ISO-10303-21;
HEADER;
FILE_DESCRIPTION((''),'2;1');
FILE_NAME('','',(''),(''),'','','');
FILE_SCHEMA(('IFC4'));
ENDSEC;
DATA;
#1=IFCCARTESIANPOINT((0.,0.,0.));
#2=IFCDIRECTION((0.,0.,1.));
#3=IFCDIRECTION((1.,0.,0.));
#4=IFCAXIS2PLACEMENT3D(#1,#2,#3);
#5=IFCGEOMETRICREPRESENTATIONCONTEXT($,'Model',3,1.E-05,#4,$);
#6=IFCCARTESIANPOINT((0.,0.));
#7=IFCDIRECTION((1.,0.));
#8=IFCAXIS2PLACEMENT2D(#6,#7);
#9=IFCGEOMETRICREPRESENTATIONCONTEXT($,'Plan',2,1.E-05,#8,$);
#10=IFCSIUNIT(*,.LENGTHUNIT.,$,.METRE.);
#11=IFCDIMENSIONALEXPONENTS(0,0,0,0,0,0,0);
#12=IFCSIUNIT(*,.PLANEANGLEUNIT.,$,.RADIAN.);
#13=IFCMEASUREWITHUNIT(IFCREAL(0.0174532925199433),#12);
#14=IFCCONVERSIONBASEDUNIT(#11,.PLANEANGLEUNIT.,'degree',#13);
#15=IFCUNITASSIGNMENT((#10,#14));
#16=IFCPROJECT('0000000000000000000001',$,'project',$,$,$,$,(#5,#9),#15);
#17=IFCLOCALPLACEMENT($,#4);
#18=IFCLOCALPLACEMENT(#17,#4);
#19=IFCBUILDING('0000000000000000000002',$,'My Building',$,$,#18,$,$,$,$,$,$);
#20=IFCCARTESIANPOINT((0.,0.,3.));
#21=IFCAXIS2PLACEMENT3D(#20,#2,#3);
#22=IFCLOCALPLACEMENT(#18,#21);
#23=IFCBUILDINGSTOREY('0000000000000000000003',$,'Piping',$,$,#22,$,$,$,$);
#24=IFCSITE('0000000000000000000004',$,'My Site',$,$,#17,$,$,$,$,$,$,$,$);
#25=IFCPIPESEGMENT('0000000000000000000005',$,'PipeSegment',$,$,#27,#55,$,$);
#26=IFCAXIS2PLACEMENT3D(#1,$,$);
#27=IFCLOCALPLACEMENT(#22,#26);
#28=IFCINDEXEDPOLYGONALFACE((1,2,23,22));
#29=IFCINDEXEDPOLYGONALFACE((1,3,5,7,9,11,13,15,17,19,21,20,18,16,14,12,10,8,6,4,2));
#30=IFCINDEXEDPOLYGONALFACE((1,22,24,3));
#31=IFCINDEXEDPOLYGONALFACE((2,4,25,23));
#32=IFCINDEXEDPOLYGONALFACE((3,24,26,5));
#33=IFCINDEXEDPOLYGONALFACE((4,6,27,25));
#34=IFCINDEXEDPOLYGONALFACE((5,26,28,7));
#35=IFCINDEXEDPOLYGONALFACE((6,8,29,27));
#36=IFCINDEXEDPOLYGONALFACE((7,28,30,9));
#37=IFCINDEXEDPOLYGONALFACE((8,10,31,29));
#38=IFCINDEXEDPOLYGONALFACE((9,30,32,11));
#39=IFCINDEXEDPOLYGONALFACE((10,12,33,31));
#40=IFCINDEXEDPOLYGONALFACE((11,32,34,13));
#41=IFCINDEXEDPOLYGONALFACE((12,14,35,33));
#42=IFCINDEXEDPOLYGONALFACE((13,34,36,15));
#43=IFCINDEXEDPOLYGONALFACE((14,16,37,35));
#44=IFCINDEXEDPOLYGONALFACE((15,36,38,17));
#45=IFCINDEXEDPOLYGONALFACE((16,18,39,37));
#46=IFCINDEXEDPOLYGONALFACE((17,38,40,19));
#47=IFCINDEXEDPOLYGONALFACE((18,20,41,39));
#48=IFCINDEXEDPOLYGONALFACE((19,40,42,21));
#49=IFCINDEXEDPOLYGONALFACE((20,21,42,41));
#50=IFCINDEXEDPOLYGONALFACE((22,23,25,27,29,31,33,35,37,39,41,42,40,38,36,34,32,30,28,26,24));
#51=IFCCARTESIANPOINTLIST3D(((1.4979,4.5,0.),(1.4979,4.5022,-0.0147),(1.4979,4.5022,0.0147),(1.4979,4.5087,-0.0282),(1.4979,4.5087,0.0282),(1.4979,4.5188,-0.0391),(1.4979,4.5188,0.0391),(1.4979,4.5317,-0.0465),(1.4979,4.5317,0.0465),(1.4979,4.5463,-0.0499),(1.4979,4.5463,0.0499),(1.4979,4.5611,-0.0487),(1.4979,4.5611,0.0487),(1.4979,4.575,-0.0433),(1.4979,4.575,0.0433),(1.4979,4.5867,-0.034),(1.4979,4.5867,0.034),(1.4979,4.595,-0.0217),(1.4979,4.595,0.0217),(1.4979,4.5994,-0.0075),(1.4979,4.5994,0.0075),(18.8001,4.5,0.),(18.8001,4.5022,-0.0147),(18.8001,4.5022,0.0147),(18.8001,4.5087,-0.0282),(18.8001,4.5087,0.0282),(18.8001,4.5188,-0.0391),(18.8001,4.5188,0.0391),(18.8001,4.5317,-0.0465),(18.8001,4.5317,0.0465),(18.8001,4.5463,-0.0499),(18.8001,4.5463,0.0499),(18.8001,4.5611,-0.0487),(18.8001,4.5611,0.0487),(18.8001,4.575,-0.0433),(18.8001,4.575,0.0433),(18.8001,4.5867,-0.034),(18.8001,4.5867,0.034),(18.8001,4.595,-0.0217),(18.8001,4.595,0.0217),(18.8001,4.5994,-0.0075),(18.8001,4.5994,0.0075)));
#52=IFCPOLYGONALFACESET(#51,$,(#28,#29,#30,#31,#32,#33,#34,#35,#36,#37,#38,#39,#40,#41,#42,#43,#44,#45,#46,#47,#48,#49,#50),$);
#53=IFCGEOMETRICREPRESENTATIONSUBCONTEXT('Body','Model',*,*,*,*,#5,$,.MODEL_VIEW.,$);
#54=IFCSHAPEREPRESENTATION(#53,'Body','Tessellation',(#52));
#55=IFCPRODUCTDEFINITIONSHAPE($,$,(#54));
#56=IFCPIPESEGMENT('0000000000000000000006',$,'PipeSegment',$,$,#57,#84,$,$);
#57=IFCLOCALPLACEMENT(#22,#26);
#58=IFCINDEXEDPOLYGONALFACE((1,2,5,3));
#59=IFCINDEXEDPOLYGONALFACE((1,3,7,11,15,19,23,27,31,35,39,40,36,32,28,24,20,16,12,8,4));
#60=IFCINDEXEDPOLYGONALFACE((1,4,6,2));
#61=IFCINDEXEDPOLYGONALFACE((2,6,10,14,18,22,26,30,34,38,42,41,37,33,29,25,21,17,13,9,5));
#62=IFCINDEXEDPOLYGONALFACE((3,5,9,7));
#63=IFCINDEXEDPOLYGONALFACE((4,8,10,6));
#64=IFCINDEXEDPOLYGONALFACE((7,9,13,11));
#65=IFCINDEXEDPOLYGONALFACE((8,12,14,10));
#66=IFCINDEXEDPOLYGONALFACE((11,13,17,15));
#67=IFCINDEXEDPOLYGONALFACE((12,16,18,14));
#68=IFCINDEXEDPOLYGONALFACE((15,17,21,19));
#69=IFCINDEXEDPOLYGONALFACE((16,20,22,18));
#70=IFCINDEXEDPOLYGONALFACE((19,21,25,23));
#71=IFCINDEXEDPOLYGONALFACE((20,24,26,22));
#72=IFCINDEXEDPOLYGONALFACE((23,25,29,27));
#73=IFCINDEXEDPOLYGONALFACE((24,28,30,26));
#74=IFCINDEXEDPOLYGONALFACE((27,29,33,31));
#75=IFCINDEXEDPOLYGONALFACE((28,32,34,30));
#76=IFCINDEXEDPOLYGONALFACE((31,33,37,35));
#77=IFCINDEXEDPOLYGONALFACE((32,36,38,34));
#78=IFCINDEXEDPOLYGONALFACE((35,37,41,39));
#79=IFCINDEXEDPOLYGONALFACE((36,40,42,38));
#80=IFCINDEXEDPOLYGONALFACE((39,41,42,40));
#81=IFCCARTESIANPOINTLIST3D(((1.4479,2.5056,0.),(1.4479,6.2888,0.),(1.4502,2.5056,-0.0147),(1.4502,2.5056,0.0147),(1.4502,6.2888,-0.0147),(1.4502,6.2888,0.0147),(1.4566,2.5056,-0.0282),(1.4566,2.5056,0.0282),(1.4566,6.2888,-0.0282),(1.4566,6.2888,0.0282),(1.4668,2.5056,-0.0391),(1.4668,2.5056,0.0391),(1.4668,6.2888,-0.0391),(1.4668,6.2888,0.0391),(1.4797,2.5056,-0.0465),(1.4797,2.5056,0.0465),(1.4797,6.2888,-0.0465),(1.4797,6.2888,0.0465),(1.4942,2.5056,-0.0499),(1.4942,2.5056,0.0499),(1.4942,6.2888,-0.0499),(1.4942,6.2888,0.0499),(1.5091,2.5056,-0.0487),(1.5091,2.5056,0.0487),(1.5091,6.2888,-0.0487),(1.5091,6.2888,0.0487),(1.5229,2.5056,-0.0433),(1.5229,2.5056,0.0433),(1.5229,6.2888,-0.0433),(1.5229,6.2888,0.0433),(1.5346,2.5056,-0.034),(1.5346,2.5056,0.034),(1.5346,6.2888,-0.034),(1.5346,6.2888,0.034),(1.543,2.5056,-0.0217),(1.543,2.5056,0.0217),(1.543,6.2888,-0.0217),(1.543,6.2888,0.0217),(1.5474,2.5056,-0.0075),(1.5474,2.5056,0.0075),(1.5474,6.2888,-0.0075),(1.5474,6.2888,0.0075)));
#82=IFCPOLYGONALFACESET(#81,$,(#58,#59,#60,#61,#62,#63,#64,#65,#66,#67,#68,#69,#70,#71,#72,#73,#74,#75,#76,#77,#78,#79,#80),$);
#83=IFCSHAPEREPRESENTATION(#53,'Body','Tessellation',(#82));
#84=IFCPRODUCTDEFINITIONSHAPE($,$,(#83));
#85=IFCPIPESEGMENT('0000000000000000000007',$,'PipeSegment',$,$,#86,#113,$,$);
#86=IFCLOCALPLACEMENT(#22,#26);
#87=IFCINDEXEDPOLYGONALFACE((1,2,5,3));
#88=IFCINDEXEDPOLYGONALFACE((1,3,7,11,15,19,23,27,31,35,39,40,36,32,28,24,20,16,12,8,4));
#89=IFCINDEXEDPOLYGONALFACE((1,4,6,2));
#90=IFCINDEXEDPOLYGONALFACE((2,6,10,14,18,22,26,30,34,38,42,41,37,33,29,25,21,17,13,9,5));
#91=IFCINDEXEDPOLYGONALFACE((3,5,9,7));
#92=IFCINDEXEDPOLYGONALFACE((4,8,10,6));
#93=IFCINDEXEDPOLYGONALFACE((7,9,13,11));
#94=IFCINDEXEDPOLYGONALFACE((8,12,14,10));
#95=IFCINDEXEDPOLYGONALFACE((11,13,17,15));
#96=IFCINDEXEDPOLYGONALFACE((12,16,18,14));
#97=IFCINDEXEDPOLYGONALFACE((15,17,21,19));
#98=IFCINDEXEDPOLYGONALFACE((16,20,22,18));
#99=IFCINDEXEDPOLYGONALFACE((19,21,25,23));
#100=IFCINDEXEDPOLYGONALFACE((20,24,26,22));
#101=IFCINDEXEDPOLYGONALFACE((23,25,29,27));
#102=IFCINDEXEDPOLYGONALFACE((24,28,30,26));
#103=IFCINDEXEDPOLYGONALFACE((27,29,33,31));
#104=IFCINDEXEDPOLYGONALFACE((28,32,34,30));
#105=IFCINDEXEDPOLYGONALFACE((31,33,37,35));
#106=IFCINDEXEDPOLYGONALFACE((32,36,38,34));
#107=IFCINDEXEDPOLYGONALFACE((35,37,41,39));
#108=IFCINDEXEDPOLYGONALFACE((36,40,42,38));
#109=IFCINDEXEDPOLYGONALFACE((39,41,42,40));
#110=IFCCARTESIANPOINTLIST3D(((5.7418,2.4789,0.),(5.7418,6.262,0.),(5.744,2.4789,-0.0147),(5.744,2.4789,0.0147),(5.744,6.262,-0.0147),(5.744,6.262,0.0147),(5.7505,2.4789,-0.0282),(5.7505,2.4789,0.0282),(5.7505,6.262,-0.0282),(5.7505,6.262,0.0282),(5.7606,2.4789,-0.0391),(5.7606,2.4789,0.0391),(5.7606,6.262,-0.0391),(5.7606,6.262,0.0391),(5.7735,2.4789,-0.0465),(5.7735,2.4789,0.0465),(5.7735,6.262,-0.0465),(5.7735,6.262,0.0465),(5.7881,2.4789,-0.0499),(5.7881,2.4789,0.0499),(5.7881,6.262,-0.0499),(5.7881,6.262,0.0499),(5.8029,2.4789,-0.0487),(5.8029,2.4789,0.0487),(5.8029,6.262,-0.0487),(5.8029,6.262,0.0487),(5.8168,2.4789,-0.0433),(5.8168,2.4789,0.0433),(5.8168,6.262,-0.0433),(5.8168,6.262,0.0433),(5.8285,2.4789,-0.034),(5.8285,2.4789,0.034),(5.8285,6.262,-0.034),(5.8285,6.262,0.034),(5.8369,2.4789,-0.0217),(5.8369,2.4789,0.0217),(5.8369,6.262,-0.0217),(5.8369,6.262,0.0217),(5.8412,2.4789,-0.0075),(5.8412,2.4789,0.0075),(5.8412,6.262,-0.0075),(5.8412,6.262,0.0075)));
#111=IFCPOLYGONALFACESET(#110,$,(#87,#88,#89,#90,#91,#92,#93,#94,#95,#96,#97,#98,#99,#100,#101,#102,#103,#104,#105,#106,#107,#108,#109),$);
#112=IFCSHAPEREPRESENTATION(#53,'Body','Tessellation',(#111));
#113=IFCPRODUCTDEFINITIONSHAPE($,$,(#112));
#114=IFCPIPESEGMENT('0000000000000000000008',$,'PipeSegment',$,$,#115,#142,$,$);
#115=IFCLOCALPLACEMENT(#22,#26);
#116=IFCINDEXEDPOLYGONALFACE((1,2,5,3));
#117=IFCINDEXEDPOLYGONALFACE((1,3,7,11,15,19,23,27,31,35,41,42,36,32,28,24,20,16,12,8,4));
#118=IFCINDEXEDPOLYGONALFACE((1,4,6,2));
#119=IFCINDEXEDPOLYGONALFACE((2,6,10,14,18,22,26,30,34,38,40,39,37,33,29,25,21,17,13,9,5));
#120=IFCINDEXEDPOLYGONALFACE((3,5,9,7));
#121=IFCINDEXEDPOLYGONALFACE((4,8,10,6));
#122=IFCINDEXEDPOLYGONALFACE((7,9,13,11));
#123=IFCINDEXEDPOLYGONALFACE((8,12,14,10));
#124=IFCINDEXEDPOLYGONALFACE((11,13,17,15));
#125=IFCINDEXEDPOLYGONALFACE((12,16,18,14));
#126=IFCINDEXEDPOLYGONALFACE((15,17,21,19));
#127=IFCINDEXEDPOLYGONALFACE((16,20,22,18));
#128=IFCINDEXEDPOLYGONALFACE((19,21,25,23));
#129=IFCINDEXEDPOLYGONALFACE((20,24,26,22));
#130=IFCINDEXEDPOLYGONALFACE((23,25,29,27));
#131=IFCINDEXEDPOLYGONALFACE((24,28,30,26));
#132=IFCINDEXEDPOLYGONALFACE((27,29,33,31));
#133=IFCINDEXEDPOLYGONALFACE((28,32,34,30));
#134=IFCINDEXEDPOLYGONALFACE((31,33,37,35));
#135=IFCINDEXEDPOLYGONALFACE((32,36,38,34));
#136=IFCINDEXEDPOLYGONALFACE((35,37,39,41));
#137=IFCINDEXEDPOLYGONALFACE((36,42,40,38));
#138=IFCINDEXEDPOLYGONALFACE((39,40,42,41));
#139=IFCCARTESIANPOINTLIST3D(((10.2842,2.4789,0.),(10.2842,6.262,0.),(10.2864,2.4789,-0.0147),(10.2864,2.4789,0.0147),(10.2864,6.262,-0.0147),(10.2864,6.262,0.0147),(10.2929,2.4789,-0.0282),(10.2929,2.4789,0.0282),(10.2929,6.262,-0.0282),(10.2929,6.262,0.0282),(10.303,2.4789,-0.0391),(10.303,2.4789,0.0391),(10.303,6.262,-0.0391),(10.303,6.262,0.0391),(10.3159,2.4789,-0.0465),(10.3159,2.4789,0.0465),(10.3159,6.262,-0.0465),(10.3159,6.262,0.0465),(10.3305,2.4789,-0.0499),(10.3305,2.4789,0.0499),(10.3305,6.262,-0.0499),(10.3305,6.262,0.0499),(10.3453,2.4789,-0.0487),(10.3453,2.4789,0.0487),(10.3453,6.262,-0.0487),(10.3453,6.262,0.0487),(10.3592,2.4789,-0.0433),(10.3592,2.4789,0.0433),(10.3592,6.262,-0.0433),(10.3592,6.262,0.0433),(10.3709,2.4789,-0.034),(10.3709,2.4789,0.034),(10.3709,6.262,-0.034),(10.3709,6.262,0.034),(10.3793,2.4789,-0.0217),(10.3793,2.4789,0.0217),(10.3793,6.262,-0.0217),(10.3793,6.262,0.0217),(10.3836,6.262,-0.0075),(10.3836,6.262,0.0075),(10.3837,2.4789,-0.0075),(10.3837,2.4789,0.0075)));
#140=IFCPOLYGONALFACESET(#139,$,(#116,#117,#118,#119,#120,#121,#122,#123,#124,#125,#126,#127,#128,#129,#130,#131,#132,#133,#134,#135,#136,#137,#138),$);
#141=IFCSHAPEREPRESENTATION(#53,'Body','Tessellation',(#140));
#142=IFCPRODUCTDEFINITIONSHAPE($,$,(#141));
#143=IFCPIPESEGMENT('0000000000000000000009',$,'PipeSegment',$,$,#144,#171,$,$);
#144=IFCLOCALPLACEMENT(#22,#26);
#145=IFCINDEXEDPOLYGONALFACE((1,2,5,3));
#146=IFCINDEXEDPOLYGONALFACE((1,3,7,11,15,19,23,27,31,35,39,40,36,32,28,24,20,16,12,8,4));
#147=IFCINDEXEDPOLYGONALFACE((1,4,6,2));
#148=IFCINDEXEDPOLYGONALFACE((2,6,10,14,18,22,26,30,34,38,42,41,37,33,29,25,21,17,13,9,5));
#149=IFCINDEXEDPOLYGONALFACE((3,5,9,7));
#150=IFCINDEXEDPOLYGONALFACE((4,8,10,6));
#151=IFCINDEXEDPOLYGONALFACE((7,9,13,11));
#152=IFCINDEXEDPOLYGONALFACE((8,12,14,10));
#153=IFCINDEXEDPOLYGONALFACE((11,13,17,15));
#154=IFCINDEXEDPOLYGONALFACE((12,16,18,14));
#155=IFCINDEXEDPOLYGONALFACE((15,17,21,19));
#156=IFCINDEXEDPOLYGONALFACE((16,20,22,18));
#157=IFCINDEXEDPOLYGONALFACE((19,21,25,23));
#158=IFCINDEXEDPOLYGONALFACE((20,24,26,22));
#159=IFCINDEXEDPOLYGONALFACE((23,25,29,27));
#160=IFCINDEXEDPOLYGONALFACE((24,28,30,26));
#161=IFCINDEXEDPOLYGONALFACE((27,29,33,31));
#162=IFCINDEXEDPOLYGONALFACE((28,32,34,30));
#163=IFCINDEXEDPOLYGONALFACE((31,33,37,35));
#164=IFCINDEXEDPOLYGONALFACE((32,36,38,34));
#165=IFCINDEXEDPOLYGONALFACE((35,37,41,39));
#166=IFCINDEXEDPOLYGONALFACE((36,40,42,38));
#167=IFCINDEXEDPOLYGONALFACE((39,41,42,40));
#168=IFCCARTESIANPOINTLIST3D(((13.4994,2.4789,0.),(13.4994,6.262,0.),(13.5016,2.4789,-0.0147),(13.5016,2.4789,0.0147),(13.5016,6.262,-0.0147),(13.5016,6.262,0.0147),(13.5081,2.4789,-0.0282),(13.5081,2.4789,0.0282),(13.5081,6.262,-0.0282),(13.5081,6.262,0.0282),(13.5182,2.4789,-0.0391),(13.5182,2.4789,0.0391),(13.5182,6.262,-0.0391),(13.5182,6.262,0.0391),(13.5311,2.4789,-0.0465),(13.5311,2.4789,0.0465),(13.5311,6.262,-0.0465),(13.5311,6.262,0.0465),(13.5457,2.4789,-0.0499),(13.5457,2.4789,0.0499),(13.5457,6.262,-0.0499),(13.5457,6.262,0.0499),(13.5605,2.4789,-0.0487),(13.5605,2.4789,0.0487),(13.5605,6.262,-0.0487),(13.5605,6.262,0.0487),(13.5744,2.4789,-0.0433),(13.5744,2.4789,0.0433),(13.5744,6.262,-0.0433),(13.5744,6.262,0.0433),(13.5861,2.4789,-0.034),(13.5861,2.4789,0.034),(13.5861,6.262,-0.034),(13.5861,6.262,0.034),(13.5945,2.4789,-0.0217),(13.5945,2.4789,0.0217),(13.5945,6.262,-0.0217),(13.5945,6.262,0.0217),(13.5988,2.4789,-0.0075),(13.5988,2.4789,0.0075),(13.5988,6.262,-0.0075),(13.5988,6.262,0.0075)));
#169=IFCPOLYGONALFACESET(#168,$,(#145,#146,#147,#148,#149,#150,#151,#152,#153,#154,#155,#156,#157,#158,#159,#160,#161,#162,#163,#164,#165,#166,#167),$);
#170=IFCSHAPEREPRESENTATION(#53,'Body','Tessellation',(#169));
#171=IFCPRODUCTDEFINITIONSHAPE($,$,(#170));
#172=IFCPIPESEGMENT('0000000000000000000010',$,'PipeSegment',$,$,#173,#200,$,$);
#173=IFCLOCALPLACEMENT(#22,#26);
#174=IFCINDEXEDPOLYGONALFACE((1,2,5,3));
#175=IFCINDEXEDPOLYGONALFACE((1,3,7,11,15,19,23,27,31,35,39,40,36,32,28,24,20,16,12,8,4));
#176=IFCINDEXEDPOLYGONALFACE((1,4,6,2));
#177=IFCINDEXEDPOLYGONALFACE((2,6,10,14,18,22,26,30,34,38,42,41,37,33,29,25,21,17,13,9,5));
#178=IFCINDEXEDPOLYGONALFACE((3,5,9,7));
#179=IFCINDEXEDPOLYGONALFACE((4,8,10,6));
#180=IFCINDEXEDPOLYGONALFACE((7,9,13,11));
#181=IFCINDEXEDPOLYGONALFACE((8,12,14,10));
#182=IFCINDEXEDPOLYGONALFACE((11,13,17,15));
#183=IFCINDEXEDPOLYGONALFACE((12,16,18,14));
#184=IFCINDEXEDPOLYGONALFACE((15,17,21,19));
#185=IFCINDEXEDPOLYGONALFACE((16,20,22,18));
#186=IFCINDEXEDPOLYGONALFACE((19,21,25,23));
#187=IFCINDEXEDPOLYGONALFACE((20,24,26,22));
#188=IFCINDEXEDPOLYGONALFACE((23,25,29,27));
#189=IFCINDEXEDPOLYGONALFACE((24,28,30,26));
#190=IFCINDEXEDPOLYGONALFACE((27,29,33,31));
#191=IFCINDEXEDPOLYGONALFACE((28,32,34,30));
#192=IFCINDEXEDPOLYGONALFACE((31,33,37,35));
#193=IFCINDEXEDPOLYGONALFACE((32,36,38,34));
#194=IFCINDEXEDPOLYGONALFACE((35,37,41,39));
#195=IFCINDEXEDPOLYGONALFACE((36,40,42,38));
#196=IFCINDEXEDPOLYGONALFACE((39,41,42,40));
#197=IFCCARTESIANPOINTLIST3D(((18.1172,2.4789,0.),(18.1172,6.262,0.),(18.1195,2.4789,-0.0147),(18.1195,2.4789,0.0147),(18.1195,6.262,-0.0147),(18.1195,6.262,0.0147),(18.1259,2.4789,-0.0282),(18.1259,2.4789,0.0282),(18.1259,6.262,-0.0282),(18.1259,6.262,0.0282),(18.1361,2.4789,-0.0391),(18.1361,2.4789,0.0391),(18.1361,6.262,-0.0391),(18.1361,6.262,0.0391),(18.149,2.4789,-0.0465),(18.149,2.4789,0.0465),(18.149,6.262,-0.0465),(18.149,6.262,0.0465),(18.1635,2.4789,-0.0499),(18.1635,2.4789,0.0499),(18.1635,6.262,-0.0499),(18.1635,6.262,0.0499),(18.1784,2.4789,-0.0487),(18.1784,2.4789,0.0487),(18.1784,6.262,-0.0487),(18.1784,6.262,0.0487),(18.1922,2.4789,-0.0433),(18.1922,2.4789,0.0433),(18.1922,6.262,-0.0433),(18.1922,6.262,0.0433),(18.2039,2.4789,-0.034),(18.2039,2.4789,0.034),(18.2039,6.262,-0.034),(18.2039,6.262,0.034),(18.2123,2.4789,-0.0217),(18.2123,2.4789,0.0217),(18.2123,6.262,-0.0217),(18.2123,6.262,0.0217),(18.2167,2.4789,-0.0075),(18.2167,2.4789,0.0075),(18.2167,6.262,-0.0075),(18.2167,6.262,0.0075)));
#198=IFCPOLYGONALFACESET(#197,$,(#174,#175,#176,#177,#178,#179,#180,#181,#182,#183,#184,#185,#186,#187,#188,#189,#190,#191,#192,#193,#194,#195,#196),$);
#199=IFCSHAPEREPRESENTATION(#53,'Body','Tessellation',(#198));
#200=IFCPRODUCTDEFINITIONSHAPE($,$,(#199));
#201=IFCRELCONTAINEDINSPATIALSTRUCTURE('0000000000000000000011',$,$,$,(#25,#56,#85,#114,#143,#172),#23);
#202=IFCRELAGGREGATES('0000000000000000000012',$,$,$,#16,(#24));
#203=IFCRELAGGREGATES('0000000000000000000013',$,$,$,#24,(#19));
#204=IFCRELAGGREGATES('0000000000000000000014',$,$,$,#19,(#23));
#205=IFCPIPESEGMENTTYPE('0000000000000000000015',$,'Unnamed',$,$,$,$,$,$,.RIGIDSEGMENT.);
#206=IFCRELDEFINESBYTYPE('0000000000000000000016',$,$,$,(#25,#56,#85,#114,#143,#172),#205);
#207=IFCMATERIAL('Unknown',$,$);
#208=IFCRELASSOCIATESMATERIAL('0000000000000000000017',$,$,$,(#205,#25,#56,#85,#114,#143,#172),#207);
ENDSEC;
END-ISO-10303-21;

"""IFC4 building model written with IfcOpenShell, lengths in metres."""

from ifc_helpers import new_model, entity, si_unit, converted_unit, frame, origin_with_axes, origin_2d_with_axis, place, context, subcontext, project, spatial, circle, extrude, material, material_profile, profile_set, profile_usage, type_object, element, save


model = new_model("IFC4")

# Units and contexts
model_context = context("Model", 3, precision=1e-05, world=origin_with_axes())
plan_context = context("Plan", 2, precision=1e-05, world=origin_2d_with_axis())
body_context = subcontext(model_context, "Body", "Model", "MODEL_VIEW")
ifc_project = project(units=[si_unit("LENGTHUNIT", "METRE"), converted_unit("PLANEANGLEUNIT", "degree", entity("IfcReal", 0.0174532925199433), si_unit("PLANEANGLEUNIT", "RADIAN"), dimensions=[0, 0, 0, 0, 0, 0, 0])], contexts=[model_context, plan_context])

# Site, building, storey
site_placement = place(None, origin_with_axes())
site = spatial("IfcSite", under=ifc_project, at=site_placement, Name="My Site")
building_placement = place(site_placement, origin_with_axes())
building = spatial("IfcBuilding", under=site, at=building_placement, Name="My Building")
storey_placement = place(building_placement, frame((0.0, 0.0, 3.0), z_axis=(0.0, 0.0, 1.0), x_axis=(1.0, 0.0, 0.0)))
storey = spatial("IfcBuildingStorey", under=building, at=storey_placement, Name="Piping")

# Pipe segments
ifc_material = material(Name="Unknown")
ifc_material_profile = material_profile(ifc_material, circle(Radius=0.05))
ifc_profile_set = profile_set([ifc_material_profile])
ifc_profile_usage_1 = profile_usage(ifc_profile_set, cardinal=5)
pipe_segment_type = type_object("IfcPipeSegmentType", Name="Unnamed", PredefinedType="RIGIDSEGMENT", material=ifc_profile_set)
pipe_segment_1_placement = place(storey_placement, frame((18.8001, 4.55, 0.0), z_axis=(-1.0, 0.0, 0.0), x_axis=(0.0, -1.0, 0.0)))
element("IfcPipeSegment", 1, at=pipe_segment_1_placement, inside=storey, type_object=pipe_segment_type, material=ifc_profile_usage_1, Name="PipeSegment", context=body_context, shape_type="SweptSolid", body=[
    extrude(circle(Radius=0.05), origin_with_axes(), (0.0, 0.0, 1.0), 17.3022),
])
ifc_profile_usage_2 = profile_usage(ifc_profile_set, cardinal=5)
pipe_segment_2_placement = place(storey_placement, frame((1.4979, 2.5056, 0.0), z_axis=(0.0, 1.0, 0.0), x_axis=(-1.0, 0.0, 0.0)))
element("IfcPipeSegment", 2, at=pipe_segment_2_placement, inside=storey, type_object=pipe_segment_type, material=ifc_profile_usage_2, Name="PipeSegment", context=body_context, shape_type="SweptSolid", body=[
    extrude(circle(Radius=0.05), origin_with_axes(), (0.0, 0.0, 1.0), 3.7832),
])
ifc_profile_usage_3 = profile_usage(ifc_profile_set, cardinal=5)
pipe_segment_3_placement = place(storey_placement, frame((5.7918, 2.4789, 0.0), z_axis=(0.0, 1.0, 0.0), x_axis=(-1.0, 0.0, 0.0)))
element("IfcPipeSegment", 3, at=pipe_segment_3_placement, inside=storey, type_object=pipe_segment_type, material=ifc_profile_usage_3, Name="PipeSegment", context=body_context, shape_type="SweptSolid", body=[
    extrude(circle(Radius=0.05), origin_with_axes(), (0.0, 0.0, 1.0), 3.7832),
])
ifc_profile_usage_4 = profile_usage(ifc_profile_set, cardinal=5)
pipe_segment_4_placement = place(storey_placement, frame((10.3342, 2.4789, 0.0), z_axis=(0.0, 1.0, 0.0), x_axis=(-1.0, 0.0, 0.0)))
element("IfcPipeSegment", 4, at=pipe_segment_4_placement, inside=storey, type_object=pipe_segment_type, material=ifc_profile_usage_4, Name="PipeSegment", context=body_context, shape_type="SweptSolid", body=[
    extrude(circle(Radius=0.05), origin_with_axes(), (0.0, 0.0, 1.0), 3.7832),
])
ifc_profile_usage_5 = profile_usage(ifc_profile_set, cardinal=5)
pipe_segment_5_placement = place(storey_placement, frame((13.5494, 2.4789, 0.0), z_axis=(0.0, 1.0, 0.0), x_axis=(-1.0, 0.0, 0.0)))
element("IfcPipeSegment", 5, at=pipe_segment_5_placement, inside=storey, type_object=pipe_segment_type, material=ifc_profile_usage_5, Name="PipeSegment", context=body_context, shape_type="SweptSolid", body=[
    extrude(circle(Radius=0.05), origin_with_axes(), (0.0, 0.0, 1.0), 3.7832),
])
ifc_profile_usage_6 = profile_usage(ifc_profile_set, cardinal=5)
pipe_segment_6_placement = place(storey_placement, frame((18.1672, 2.4789, 0.0), z_axis=(0.0, 1.0, 0.0), x_axis=(-1.0, 0.0, 0.0)))
element("IfcPipeSegment", 6, at=pipe_segment_6_placement, inside=storey, type_object=pipe_segment_type, material=ifc_profile_usage_6, Name="PipeSegment", context=body_context, shape_type="SweptSolid", body=[
    extrude(circle(Radius=0.05), origin_with_axes(), (0.0, 0.0, 1.0), 3.7832),
])

save(model, "model.ifc")
